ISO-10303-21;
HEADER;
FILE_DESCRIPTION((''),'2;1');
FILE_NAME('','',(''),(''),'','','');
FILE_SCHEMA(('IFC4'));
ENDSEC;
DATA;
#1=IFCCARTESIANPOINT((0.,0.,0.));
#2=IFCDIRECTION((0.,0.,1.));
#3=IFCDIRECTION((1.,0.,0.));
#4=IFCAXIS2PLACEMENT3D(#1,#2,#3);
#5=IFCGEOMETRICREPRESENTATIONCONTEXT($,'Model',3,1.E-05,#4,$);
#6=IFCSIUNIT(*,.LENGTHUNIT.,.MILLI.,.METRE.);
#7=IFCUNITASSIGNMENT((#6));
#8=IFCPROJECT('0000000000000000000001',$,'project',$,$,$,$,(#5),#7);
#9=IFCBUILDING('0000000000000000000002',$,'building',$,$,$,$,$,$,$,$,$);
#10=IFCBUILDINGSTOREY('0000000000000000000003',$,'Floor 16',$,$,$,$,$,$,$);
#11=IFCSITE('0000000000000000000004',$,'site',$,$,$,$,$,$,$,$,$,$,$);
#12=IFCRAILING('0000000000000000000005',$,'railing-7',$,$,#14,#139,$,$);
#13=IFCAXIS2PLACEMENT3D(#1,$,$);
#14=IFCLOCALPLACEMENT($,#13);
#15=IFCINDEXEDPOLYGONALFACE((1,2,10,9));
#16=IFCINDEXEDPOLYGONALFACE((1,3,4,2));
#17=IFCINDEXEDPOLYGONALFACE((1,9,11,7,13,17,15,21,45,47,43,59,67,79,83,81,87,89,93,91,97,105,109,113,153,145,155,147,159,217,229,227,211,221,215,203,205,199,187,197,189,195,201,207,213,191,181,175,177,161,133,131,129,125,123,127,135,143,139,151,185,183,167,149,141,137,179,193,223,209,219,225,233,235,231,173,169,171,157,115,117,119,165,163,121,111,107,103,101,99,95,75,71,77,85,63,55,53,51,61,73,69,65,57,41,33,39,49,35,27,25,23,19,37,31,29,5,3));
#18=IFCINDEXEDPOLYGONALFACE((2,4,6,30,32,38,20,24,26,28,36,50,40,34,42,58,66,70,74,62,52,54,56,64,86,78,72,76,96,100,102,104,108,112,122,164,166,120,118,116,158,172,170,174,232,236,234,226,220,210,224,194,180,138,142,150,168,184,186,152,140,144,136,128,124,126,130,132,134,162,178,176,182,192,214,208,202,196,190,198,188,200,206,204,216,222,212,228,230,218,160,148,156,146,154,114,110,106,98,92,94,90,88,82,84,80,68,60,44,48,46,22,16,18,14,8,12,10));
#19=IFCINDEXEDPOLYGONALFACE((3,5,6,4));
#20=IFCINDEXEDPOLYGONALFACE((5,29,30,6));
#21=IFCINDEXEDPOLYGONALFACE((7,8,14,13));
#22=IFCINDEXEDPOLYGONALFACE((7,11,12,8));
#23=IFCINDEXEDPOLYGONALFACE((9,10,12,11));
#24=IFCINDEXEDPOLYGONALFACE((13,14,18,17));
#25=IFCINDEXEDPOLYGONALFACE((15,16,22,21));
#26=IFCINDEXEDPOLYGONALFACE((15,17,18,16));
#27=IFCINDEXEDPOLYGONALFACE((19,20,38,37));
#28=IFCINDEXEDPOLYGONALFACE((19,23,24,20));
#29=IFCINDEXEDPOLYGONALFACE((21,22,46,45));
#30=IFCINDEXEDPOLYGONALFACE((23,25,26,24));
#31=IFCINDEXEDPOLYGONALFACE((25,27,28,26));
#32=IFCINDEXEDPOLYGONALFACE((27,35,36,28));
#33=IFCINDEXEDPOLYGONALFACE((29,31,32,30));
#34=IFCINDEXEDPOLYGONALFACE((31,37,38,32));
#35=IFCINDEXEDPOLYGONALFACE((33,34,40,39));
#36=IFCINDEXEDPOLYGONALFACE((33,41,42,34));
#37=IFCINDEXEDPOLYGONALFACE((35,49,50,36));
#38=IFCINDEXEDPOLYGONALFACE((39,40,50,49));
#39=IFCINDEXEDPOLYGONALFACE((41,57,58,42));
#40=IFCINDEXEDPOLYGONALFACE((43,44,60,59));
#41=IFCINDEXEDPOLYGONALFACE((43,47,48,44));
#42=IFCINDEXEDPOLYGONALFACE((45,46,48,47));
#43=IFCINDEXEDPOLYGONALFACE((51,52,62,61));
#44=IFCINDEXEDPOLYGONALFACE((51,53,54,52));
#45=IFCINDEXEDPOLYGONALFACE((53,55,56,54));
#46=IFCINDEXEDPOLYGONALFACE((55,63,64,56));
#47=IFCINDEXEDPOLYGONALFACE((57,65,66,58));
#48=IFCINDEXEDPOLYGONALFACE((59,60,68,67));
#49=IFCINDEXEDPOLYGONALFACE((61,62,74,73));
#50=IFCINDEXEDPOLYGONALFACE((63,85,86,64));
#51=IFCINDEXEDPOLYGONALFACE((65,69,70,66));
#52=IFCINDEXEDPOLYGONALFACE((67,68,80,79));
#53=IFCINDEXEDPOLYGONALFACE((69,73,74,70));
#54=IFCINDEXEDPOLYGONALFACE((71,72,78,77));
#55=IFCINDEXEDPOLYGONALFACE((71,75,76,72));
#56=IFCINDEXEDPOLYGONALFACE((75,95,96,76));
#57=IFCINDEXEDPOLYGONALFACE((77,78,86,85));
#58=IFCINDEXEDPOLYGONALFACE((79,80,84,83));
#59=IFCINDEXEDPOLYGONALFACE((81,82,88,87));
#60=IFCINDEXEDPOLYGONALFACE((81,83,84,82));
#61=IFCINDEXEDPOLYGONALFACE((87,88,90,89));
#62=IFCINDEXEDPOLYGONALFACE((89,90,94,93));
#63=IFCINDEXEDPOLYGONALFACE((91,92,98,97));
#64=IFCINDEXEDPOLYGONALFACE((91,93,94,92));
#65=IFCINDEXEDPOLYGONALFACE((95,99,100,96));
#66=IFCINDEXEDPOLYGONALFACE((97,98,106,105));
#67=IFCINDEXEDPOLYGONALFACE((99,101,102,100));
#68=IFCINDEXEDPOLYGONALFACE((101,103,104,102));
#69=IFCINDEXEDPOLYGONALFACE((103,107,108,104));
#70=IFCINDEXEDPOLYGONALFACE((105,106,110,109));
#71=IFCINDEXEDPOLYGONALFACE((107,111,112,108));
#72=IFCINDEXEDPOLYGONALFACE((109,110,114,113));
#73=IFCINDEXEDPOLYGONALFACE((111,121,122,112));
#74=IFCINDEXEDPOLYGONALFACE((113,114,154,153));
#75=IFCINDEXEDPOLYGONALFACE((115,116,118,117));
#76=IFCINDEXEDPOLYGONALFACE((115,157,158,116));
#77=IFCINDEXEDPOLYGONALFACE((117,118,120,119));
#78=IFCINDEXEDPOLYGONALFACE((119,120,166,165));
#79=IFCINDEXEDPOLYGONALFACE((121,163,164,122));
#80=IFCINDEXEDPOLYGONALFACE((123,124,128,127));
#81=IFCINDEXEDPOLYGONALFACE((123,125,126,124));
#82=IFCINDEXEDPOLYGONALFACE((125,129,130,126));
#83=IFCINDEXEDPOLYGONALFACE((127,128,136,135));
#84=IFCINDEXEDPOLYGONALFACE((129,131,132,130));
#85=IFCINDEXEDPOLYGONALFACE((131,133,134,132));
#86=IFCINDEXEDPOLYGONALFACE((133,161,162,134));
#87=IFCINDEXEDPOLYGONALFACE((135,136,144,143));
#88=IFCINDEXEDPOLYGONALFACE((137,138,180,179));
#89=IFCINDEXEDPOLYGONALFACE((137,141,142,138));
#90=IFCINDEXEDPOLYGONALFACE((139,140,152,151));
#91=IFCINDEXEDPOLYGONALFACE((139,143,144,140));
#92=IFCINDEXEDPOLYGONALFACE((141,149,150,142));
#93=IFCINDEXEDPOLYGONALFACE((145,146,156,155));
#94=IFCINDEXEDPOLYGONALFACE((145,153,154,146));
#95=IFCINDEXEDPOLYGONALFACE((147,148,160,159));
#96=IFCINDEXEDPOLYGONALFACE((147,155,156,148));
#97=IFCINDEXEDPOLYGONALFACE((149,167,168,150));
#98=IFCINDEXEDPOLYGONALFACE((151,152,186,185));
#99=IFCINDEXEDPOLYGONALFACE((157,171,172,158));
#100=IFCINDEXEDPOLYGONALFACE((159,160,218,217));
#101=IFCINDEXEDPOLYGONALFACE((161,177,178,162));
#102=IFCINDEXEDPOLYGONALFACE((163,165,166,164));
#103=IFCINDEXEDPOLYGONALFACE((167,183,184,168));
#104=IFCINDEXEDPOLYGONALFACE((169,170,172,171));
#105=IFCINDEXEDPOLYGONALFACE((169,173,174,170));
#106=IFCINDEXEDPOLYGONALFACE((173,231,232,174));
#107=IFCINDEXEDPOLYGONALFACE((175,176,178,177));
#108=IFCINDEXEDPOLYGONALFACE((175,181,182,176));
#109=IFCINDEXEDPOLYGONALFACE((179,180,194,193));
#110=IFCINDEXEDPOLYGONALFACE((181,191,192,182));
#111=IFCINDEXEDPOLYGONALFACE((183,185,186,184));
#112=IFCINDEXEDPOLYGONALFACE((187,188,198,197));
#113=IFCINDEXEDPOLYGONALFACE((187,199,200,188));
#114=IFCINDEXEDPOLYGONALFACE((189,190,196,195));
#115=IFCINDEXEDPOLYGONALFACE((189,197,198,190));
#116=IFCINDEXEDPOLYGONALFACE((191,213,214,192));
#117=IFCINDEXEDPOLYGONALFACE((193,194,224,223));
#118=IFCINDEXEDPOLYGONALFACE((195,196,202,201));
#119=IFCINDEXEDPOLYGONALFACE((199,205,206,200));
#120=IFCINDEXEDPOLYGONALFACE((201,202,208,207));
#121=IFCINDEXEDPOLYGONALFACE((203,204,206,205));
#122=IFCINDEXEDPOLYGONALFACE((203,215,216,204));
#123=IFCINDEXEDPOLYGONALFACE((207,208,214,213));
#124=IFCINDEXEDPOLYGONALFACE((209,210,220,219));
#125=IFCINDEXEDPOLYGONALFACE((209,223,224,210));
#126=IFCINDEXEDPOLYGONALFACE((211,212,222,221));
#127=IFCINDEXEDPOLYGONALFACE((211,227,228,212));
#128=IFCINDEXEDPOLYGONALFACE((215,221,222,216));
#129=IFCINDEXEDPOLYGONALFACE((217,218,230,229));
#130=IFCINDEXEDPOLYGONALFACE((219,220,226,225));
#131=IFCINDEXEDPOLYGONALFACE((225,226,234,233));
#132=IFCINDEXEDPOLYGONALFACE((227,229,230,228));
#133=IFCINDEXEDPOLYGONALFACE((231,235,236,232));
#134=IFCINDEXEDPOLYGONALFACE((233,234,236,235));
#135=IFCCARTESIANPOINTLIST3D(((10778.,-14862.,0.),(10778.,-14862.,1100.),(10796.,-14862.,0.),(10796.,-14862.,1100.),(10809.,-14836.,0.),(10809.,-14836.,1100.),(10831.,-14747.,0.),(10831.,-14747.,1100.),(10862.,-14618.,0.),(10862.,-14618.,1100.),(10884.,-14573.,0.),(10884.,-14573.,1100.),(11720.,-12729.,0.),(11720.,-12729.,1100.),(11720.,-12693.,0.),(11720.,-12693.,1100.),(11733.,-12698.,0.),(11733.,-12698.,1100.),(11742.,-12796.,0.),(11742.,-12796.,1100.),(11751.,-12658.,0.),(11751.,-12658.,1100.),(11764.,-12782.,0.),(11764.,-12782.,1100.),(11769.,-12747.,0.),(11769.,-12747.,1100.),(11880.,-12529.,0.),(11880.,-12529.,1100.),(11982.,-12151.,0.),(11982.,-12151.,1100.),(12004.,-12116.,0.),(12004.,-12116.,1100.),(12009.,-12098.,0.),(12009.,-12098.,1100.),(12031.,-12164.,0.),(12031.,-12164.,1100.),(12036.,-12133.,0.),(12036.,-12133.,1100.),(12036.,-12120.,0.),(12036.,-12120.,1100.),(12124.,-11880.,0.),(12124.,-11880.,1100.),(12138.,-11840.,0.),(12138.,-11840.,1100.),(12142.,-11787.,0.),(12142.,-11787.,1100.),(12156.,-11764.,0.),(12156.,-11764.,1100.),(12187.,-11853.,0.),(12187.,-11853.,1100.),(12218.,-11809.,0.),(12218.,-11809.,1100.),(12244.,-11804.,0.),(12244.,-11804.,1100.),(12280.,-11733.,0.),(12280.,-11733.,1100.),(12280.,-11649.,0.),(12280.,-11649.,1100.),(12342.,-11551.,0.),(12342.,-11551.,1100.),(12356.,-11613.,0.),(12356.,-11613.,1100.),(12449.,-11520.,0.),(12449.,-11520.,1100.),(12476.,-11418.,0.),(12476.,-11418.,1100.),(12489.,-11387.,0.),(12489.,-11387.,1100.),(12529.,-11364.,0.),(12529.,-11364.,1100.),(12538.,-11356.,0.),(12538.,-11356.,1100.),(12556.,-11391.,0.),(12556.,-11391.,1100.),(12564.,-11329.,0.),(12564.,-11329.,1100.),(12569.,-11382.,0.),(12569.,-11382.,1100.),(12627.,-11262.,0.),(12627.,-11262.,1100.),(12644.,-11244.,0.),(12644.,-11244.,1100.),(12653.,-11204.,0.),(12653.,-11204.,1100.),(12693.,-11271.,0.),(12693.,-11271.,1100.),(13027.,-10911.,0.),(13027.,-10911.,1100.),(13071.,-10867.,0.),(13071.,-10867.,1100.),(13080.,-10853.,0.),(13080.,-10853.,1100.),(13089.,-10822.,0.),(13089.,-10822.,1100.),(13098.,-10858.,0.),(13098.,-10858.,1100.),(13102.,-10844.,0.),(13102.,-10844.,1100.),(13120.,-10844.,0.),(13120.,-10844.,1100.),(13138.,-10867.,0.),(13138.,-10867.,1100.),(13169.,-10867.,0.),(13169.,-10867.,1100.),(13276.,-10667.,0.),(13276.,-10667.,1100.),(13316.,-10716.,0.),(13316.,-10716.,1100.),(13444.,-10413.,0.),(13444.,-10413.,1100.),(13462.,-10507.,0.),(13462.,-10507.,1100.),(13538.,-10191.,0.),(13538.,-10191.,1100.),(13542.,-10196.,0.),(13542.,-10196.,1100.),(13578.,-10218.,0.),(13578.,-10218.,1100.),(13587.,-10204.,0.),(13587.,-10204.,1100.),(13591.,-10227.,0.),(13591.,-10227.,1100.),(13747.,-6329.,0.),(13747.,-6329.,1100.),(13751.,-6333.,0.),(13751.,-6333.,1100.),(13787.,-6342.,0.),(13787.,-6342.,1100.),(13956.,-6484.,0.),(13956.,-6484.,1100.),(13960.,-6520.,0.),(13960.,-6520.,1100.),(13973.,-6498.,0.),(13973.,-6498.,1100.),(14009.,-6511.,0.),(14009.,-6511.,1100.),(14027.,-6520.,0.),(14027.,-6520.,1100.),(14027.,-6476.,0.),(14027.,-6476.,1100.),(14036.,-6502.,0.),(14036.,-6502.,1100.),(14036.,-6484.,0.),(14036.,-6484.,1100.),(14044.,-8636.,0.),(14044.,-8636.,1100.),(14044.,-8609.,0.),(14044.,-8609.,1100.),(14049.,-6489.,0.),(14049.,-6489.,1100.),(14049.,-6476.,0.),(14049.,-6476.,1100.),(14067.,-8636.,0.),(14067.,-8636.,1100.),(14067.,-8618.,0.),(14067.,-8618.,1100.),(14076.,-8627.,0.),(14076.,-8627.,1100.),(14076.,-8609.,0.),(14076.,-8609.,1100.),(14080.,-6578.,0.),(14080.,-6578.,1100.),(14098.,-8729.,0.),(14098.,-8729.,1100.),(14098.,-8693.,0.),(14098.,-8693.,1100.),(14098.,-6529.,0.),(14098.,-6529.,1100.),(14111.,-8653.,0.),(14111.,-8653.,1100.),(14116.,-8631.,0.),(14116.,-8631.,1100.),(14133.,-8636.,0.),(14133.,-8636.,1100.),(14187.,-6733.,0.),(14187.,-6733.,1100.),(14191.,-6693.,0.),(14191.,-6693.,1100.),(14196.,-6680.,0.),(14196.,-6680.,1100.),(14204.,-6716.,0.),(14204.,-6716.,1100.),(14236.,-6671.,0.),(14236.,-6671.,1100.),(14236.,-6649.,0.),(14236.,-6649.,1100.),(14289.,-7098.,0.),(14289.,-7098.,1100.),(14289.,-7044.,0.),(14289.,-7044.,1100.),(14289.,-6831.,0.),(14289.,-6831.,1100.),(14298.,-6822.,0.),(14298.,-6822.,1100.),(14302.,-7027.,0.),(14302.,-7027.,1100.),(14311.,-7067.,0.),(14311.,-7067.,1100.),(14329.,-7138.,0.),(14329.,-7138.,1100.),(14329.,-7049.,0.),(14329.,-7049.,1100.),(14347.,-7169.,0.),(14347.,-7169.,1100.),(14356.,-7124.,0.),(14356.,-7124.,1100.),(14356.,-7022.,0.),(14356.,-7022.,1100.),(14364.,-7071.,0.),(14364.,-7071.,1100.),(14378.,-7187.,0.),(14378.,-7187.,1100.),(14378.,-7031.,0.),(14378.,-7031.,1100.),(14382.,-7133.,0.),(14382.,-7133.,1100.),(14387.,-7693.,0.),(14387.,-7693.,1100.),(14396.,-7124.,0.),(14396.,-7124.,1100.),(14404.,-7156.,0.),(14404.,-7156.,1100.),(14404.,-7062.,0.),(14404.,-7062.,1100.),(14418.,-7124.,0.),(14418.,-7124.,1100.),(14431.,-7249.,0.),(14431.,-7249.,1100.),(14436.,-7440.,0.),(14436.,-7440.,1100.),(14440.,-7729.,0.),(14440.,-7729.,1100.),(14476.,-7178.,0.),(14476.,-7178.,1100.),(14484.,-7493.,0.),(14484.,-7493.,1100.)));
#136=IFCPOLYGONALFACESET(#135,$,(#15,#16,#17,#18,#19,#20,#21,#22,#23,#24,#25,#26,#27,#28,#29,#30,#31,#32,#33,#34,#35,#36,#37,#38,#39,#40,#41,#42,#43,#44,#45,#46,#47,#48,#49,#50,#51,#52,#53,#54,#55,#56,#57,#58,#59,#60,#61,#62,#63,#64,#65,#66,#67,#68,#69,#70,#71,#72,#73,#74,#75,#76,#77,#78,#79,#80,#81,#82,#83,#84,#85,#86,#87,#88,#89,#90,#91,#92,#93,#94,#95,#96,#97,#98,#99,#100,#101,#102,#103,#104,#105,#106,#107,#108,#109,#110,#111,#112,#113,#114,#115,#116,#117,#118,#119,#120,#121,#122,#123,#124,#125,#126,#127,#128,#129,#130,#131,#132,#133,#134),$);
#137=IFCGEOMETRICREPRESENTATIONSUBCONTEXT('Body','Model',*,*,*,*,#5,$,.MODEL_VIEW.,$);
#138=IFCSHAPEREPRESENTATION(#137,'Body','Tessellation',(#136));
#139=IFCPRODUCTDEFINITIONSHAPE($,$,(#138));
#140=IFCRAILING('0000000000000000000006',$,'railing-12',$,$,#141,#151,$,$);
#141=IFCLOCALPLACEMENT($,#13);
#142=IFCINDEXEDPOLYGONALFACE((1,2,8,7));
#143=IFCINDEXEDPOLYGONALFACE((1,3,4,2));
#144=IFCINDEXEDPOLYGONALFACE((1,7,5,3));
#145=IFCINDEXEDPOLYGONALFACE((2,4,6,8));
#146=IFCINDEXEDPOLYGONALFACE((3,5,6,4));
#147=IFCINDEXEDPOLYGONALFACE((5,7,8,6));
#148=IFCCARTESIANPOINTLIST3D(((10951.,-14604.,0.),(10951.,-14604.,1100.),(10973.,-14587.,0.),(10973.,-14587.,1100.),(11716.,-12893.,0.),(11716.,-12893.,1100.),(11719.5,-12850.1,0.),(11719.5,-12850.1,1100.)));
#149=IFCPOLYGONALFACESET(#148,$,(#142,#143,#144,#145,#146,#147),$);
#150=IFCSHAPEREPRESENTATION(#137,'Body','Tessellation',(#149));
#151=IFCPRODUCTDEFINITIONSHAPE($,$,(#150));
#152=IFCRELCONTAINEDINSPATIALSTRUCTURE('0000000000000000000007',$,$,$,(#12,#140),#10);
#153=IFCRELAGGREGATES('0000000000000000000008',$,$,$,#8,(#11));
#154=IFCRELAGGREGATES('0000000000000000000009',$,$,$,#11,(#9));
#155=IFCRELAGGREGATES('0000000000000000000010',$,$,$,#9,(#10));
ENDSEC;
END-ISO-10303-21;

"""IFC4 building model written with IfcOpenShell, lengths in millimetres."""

from ifc_helpers import new_model, si_unit, origin_with_axes, place, context, subcontext, project, spatial, indexed_curve, outline, extrude, element, save


model = new_model("IFC4")

# Units and contexts
model_context = context("Model", 3, precision=1e-05, world=origin_with_axes())
body_context = subcontext(model_context, "Body", "Model", "MODEL_VIEW")
ifc_project = project(units=[si_unit("LENGTHUNIT", "METRE", prefix="MILLI")], contexts=[model_context])

# Site, building, storey
site = spatial("IfcSite", under=ifc_project, Name="site")
building = spatial("IfcBuilding", under=site, Name="building")
storey = spatial("IfcBuildingStorey", under=building, Name="Floor 16")

# Railings
railing_1_placement = place(None, origin_with_axes())
element("IfcRailing", 1, at=railing_1_placement, inside=storey, Name="railing-7", context=body_context, shape_type="SweptSolid", body=[
    extrude(outline(indexed_curve([(13747.0, -6329.0), (13751.0, -6333.0), (13956.0, -6484.0), (13960.0, -6520.0), (13973.0, -6498.0), (14080.0, -6578.0), (14191.0, -6693.0), (14187.0, -6733.0), (14204.0, -6716.0), (14289.0, -6831.0), (14378.0, -7031.0), (14356.0, -7022.0), (14329.0, -7049.0), (14302.0, -7027.0), (14289.0, -7044.0), (14311.0, -7067.0), (14289.0, -7098.0), (14329.0, -7138.0), (14356.0, -7124.0), (14347.0, -7169.0), (14382.0, -7133.0), (14404.0, -7156.0), (14378.0, -7187.0), (14431.0, -7249.0), (14436.0, -7440.0), (14387.0, -7693.0), (14076.0, -8609.0), (14044.0, -8609.0), (14067.0, -8618.0), (14044.0, -8636.0), (14067.0, -8636.0), (13538.0, -10191.0), (13444.0, -10413.0), (13276.0, -10667.0), (13102.0, -10844.0), (13080.0, -10853.0), (13089.0, -10822.0), (13071.0, -10867.0), (13027.0, -10911.0), (12644.0, -11244.0), (12653.0, -11204.0), (12627.0, -11262.0), (12489.0, -11387.0), (12342.0, -11551.0), (12138.0, -11840.0), (12156.0, -11764.0), (12142.0, -11787.0), (11751.0, -12658.0), (11720.0, -12693.0), (11733.0, -12698.0), (11720.0, -12729.0), (10831.0, -14747.0), (10884.0, -14573.0), (10862.0, -14618.0), (10778.0, -14862.0), (10796.0, -14862.0), (10809.0, -14836.0), (11982.0, -12151.0), (12004.0, -12116.0), (12036.0, -12133.0), (11742.0, -12796.0), (11764.0, -12782.0), (11769.0, -12747.0), (11880.0, -12529.0), (12031.0, -12164.0), (12187.0, -11853.0), (12036.0, -12120.0), (12009.0, -12098.0), (12124.0, -11880.0), (12280.0, -11649.0), (12476.0, -11418.0), (12529.0, -11364.0), (12556.0, -11391.0), (12356.0, -11613.0), (12218.0, -11809.0), (12244.0, -11804.0), (12280.0, -11733.0), (12449.0, -11520.0), (12693.0, -11271.0), (12569.0, -11382.0), (12538.0, -11356.0), (12564.0, -11329.0), (13098.0, -10858.0), (13120.0, -10844.0), (13138.0, -10867.0), (13169.0, -10867.0), (13316.0, -10716.0), (13462.0, -10507.0), (13591.0, -10227.0), (14098.0, -8729.0), (14098.0, -8693.0), (13587.0, -10204.0), (13578.0, -10218.0), (13542.0, -10196.0), (14076.0, -8627.0), (14116.0, -8631.0), (14111.0, -8653.0), (14133.0, -8636.0), (14440.0, -7729.0), (14484.0, -7493.0), (14476.0, -7178.0), (14418.0, -7124.0), (14396.0, -7124.0), (14364.0, -7071.0), (14404.0, -7062.0), (14298.0, -6822.0), (14196.0, -6680.0), (14027.0, -6520.0), (14036.0, -6502.0), (14049.0, -6489.0), (14098.0, -6529.0), (14236.0, -6671.0), (14236.0, -6649.0), (14049.0, -6476.0), (14027.0, -6476.0), (14036.0, -6484.0), (14009.0, -6511.0), (13787.0, -6342.0)])), None, (0.0, 0.0, 1.0), 1100.0),
])
railing_2_placement = place(None, origin_with_axes())
element("IfcRailing", 2, at=railing_2_placement, inside=storey, Name="railing-12", context=body_context, shape_type="SweptSolid", body=[
    extrude(outline(indexed_curve([(11719.5, -12850.1), (10951.0, -14604.0), (10973.0, -14587.0), (11716.0, -12893.0)])), None, (0.0, 0.0, 1.0), 1100.0),
])

save(model, "model.ifc")
